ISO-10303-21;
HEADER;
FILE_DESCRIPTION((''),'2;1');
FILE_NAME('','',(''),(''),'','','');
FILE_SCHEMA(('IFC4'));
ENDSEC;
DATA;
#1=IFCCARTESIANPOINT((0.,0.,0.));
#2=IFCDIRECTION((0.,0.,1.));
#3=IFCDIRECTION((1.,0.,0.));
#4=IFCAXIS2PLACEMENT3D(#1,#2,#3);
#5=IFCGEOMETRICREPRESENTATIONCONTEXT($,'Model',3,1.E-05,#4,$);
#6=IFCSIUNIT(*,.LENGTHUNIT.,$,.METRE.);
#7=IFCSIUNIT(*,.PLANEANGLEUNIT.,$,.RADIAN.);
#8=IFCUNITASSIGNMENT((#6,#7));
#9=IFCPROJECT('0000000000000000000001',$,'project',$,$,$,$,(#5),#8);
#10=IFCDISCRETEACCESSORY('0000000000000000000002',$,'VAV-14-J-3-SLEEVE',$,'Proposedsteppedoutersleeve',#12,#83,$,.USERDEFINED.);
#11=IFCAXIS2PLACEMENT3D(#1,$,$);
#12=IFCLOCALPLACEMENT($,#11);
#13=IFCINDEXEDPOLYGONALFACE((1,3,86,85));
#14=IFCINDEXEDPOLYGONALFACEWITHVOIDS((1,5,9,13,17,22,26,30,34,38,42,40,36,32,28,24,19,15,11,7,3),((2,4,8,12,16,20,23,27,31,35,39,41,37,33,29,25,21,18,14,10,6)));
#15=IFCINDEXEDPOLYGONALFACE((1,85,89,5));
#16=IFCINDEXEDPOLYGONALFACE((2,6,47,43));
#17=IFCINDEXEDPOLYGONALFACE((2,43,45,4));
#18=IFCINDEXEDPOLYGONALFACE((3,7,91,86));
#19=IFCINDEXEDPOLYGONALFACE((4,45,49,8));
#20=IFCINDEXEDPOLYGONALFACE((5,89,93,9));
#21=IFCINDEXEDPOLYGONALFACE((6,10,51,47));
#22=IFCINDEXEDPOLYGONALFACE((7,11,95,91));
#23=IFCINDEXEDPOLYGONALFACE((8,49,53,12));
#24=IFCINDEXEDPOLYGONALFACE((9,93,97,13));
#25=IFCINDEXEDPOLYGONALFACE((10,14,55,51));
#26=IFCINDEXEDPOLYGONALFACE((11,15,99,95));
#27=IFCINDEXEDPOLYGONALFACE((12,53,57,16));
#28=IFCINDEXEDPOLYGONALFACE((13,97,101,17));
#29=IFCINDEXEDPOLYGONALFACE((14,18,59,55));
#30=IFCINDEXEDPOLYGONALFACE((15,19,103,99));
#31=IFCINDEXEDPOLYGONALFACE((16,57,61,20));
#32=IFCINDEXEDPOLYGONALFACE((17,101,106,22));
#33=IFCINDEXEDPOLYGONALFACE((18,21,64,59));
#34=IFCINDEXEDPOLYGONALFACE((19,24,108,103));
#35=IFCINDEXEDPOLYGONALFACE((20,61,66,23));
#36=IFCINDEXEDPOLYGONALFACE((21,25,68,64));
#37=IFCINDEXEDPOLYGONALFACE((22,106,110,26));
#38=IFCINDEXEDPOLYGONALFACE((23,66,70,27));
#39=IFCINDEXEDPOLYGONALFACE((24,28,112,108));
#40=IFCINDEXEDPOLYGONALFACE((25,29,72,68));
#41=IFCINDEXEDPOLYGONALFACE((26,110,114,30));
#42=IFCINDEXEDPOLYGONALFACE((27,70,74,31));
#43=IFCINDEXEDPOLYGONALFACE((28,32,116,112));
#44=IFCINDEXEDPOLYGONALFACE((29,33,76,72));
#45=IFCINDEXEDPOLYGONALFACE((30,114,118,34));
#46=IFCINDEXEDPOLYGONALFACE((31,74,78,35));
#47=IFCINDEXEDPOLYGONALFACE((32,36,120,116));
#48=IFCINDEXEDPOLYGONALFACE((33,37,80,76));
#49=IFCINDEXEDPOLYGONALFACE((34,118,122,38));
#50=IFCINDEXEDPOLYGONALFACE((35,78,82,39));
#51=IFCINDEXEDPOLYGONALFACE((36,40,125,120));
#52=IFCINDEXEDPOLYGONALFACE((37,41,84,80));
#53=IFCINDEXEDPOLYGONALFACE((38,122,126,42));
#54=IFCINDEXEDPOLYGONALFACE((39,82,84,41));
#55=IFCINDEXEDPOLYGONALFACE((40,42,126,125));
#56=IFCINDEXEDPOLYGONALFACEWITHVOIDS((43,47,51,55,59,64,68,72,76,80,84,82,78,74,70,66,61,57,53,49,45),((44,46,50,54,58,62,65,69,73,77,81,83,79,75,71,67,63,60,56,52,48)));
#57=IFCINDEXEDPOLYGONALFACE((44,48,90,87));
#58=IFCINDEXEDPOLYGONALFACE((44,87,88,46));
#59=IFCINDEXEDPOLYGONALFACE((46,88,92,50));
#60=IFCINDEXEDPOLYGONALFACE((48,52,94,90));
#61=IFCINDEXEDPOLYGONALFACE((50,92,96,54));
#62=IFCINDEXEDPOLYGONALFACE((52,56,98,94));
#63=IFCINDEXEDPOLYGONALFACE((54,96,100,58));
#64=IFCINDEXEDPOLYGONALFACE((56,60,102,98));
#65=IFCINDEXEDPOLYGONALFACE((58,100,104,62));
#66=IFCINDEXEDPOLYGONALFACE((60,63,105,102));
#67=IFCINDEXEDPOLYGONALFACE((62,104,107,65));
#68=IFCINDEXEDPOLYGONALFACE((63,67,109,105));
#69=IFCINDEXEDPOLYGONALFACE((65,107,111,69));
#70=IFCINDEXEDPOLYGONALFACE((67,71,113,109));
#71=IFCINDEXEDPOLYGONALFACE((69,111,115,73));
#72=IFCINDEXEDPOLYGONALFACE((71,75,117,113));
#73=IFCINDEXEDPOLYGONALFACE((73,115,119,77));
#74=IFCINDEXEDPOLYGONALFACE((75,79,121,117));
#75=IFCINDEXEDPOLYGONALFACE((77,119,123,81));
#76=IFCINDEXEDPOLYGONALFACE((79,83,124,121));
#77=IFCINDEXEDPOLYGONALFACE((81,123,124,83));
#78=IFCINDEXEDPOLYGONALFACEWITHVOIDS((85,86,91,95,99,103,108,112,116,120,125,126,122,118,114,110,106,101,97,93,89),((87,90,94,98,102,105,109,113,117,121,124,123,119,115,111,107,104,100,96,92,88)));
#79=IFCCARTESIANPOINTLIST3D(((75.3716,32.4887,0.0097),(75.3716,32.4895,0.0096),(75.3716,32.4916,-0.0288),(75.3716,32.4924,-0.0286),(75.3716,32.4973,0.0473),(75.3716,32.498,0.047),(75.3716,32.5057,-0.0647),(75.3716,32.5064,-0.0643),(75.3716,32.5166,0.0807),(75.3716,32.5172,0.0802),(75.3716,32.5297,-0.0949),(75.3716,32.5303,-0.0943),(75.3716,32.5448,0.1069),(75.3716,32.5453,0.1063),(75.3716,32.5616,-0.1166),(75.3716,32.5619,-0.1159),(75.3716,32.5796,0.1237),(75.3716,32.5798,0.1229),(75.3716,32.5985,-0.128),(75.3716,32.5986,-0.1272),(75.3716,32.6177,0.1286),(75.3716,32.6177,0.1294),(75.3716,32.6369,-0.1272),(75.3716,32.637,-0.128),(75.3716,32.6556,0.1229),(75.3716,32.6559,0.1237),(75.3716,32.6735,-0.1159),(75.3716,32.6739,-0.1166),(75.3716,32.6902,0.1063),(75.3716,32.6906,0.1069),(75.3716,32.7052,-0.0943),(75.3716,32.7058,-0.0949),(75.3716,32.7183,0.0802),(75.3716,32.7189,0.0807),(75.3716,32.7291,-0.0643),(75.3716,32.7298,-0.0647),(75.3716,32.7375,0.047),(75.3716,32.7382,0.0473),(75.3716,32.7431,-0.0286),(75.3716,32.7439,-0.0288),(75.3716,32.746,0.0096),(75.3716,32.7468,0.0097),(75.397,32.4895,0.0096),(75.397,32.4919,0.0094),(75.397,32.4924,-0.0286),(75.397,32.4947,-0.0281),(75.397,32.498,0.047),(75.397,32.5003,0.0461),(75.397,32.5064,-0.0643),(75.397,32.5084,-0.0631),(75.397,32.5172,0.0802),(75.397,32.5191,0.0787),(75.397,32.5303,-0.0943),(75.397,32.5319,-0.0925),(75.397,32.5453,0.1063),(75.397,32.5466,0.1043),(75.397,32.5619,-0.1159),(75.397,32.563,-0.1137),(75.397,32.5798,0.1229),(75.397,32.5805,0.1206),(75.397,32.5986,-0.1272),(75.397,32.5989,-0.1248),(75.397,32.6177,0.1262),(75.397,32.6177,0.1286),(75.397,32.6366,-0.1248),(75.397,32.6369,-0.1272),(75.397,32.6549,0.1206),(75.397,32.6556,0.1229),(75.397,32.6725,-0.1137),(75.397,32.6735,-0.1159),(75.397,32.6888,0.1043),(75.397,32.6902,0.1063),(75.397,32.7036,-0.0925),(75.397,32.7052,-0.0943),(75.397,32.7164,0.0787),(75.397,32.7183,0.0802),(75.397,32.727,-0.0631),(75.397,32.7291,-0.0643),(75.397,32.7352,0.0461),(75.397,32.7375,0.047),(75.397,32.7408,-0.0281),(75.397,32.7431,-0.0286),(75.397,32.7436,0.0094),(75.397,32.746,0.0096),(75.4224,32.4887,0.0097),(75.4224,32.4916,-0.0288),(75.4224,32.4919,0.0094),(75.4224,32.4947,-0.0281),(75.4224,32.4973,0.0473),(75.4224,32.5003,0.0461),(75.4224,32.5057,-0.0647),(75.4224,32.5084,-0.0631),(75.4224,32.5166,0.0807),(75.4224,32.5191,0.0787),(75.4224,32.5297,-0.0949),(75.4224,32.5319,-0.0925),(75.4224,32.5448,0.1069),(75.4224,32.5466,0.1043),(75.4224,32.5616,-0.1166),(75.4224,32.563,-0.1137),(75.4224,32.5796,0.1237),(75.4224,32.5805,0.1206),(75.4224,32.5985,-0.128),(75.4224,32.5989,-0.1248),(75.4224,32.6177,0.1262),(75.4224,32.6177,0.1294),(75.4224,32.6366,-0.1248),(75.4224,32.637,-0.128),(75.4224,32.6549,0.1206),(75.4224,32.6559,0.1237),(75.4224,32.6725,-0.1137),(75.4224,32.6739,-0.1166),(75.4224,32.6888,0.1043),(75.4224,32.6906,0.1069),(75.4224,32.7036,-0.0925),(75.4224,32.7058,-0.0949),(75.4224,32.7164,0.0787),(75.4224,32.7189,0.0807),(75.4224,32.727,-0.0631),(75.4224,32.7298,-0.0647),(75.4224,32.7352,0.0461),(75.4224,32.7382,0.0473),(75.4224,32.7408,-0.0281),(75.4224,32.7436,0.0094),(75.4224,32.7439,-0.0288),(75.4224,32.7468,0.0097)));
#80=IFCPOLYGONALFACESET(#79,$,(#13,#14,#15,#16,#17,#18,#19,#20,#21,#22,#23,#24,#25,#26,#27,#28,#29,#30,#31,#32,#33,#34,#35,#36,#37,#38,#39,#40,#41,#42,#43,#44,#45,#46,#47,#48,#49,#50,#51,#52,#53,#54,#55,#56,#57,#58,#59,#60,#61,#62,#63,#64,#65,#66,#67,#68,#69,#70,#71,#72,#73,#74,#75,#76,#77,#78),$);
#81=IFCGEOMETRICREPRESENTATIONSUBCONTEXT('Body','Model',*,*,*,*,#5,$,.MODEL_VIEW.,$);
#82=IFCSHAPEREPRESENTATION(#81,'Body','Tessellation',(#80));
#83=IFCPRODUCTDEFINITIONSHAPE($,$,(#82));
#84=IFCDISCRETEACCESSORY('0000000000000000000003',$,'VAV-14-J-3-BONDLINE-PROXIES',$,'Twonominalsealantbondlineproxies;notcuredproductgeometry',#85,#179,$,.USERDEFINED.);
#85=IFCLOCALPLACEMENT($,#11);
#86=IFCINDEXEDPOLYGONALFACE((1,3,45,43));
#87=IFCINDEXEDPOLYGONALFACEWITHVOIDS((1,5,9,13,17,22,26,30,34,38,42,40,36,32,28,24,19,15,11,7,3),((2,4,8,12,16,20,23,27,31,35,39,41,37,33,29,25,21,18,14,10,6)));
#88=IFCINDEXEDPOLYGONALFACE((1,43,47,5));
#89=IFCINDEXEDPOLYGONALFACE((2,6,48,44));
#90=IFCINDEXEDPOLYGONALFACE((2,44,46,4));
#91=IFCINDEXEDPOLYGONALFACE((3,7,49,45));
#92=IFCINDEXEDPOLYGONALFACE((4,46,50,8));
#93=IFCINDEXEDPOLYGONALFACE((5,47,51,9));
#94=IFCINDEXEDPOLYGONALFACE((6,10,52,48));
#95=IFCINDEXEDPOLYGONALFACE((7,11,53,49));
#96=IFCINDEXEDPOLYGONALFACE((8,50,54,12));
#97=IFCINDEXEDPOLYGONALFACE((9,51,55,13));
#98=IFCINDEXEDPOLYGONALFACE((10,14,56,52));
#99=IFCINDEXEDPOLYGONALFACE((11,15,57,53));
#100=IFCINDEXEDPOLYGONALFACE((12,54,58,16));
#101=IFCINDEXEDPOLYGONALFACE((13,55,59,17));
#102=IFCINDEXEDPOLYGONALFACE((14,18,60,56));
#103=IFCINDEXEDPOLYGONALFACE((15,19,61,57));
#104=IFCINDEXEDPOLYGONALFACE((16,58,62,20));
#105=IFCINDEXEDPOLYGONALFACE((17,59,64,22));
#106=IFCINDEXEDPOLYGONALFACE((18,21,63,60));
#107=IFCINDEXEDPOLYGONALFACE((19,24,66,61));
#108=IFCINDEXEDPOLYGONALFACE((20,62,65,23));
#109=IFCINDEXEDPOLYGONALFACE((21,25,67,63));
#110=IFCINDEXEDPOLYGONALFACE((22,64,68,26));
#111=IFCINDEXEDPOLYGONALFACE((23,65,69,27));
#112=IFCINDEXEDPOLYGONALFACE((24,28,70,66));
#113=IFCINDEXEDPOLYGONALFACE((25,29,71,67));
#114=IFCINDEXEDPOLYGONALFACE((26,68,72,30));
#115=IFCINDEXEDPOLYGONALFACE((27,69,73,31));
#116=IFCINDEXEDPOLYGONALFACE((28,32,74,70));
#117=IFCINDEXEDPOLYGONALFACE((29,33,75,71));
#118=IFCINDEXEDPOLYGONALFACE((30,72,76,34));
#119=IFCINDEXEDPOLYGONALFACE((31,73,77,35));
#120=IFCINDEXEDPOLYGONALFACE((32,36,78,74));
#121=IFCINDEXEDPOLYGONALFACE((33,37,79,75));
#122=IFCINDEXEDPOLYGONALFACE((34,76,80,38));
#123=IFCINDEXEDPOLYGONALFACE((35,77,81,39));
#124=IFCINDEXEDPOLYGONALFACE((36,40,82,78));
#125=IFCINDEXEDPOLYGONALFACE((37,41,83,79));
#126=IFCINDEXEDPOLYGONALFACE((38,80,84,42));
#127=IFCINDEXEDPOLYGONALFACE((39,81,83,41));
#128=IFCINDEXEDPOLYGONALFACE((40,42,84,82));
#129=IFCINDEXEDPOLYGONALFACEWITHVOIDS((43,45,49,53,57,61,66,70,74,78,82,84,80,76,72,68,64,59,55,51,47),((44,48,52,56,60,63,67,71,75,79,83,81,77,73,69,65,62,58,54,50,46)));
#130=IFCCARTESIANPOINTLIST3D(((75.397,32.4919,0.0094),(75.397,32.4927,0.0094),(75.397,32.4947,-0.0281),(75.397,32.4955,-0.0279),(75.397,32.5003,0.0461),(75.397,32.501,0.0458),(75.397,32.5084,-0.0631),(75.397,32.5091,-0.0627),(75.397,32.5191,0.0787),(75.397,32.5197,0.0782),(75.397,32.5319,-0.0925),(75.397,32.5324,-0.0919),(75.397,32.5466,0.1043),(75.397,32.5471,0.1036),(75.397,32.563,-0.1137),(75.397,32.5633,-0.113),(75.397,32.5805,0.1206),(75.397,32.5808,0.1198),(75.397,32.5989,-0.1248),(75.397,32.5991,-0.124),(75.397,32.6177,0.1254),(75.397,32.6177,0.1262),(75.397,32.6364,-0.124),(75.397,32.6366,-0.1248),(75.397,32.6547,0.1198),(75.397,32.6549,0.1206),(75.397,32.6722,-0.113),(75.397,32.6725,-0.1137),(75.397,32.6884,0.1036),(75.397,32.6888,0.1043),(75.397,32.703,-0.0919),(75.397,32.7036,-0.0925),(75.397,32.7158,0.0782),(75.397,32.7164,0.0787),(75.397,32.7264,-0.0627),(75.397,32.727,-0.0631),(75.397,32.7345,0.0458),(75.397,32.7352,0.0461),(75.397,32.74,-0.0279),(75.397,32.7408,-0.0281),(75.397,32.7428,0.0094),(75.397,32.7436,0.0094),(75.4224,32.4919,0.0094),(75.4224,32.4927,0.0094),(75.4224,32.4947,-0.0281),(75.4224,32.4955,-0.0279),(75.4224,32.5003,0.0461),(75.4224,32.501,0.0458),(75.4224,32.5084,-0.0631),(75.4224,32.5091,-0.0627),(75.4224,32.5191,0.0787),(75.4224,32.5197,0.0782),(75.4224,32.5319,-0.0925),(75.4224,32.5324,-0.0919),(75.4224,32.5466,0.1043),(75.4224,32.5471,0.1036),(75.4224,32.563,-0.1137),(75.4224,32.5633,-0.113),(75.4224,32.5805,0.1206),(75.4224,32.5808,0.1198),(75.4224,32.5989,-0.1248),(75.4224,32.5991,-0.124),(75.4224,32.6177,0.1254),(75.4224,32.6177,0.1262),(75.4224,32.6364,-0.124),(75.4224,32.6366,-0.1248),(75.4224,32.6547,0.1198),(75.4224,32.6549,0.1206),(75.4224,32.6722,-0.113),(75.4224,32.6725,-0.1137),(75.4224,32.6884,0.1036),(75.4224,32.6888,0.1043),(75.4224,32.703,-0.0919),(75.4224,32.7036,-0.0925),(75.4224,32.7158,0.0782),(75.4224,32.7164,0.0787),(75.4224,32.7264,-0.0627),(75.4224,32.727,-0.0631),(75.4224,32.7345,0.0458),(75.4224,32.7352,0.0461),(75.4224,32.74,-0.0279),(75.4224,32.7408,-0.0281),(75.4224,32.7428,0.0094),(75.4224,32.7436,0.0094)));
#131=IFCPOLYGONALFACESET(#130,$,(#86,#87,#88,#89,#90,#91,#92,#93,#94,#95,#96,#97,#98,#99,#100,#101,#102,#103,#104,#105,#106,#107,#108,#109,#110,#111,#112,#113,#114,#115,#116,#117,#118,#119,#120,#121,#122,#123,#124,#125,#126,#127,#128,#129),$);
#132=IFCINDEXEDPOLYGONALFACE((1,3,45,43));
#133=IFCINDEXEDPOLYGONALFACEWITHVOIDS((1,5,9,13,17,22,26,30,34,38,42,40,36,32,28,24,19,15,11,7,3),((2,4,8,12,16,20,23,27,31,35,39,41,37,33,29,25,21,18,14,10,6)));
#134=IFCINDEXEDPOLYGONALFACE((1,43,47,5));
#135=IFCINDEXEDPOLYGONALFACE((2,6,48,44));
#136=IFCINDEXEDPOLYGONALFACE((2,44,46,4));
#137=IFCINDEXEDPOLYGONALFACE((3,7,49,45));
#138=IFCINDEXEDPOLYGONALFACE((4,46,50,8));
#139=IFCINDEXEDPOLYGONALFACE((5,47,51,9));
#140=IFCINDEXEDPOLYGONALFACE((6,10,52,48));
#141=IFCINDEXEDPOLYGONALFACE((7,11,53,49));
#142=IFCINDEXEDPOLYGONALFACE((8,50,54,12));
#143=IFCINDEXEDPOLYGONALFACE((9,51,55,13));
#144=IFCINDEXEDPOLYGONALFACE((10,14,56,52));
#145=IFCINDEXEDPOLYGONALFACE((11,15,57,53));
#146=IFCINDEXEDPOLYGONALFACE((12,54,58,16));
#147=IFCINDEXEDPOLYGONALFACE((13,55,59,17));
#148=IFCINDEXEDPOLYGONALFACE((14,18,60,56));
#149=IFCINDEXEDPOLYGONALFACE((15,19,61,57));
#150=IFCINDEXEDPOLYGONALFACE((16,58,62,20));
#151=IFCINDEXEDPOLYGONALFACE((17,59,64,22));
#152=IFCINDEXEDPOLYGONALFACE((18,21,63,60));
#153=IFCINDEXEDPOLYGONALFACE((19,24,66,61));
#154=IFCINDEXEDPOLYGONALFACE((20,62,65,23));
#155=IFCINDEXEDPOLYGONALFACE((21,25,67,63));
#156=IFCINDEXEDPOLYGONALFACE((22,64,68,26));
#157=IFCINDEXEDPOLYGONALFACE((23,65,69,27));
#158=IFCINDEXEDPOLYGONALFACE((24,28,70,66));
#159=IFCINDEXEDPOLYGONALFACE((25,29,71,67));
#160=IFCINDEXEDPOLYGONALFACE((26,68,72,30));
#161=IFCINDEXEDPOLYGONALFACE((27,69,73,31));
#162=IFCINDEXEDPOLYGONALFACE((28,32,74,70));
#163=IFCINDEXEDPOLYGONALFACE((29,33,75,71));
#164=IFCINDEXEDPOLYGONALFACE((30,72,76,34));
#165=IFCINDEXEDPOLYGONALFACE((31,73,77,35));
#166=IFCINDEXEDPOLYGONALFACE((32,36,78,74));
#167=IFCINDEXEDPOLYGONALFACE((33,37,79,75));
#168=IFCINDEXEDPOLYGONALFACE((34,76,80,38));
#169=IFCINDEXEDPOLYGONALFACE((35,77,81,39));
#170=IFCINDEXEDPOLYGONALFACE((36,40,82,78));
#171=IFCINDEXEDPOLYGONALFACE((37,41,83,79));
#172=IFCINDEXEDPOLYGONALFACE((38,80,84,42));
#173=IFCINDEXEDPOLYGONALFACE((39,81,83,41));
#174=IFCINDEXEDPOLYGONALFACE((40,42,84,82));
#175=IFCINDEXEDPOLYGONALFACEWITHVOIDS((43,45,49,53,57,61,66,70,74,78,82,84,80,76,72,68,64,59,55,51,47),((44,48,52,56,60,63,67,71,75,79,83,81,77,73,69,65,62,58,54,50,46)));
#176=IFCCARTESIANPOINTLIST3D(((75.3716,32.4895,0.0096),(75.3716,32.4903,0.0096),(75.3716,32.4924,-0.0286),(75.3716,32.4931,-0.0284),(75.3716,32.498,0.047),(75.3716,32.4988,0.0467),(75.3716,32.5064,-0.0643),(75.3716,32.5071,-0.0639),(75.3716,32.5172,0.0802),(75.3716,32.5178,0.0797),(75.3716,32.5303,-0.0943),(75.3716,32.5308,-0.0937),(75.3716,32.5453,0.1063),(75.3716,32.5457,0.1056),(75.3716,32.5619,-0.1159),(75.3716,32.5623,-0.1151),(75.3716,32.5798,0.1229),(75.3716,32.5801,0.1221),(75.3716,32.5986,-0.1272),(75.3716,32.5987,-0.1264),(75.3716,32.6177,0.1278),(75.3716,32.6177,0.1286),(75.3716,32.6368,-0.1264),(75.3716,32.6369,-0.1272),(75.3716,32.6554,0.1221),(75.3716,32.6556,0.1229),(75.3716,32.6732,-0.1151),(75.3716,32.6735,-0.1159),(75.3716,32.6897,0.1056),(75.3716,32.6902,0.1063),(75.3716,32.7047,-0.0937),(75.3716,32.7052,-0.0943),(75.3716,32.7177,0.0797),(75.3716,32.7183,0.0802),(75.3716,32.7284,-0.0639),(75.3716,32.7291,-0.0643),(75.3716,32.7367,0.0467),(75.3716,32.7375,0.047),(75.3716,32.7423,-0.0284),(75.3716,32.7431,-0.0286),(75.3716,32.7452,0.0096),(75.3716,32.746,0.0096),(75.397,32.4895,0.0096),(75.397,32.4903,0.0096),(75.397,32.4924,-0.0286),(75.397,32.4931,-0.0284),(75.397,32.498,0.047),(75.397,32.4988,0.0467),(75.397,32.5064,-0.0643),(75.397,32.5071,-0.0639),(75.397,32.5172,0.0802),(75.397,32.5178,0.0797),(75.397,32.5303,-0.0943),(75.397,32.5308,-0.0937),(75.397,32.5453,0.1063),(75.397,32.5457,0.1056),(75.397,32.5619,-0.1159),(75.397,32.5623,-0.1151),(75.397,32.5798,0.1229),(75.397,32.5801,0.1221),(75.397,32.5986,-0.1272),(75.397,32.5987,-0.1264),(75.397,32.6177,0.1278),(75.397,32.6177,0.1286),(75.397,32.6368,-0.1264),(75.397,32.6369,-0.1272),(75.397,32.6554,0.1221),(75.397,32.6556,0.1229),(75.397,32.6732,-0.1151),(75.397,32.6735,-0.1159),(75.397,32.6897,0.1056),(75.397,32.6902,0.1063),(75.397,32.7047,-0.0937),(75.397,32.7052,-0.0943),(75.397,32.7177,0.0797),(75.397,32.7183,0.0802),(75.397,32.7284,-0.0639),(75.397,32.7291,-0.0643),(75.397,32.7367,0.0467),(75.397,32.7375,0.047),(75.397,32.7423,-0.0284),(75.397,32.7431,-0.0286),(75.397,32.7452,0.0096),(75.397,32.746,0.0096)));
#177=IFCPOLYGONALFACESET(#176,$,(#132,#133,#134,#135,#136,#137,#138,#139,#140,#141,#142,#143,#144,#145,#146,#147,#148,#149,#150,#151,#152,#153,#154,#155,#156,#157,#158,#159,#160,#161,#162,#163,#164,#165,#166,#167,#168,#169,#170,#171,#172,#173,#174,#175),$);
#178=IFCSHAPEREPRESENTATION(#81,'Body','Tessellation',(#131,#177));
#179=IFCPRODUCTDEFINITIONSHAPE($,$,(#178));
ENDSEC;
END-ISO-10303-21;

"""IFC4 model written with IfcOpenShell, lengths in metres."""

from ifc_helpers import new_model, entity, si_unit, frame, origin_with_axes, place, context, subcontext, project, element, save


model = new_model("IFC4")

# Units and contexts
model_context = context("Model", 3, precision=1e-05, world=origin_with_axes())
body_context = subcontext(model_context, "Body", "Model", "MODEL_VIEW")
ifc_project = project(units=[si_unit("LENGTHUNIT", "METRE"), si_unit("PLANEANGLEUNIT", "RADIAN")], contexts=[model_context])

# Discrete accessories
discrete_accessory_1_placement = place(None, frame((75.397, 32.6177, 0.0), z_axis=(0.0, -1.0, 0.0), x_axis=(0.0, 0.0, 1.0)))
element("IfcDiscreteAccessory", 1, at=discrete_accessory_1_placement, Name="VAV-14-J-3-SLEEVE", ObjectType="Proposedsteppedoutersleeve", PredefinedType="USERDEFINED", context=body_context, shape_type="SweptSolid", body=[
    entity("IfcRevolvedAreaSolid", entity("IfcArbitraryClosedProfileDef", "AREA", None, entity("IfcPolyline", [entity("IfcCartesianPoint", [0.1262, -0.0254]), entity("IfcCartesianPoint", [0.1294, -0.0254]), entity("IfcCartesianPoint", [0.1294, 0.0254]), entity("IfcCartesianPoint", [0.1286, 0.0254]), entity("IfcCartesianPoint", [0.1286, 0.0]), entity("IfcCartesianPoint", [0.1262, 0.0]), entity("IfcCartesianPoint", [0.1262, -0.0254])])), entity("IfcAxis2Placement3D", entity("IfcCartesianPoint", [0.0, 0.0, 0.0])), entity("IfcAxis1Placement", entity("IfcCartesianPoint", [0.0, 0.0, 0.0]), entity("IfcDirection", [0.0, 1.0, 0.0])), 6.283185),
])
discrete_accessory_2_placement = place(None, frame((75.397, 32.6177, 0.0), z_axis=(0.0, -1.0, 0.0), x_axis=(0.0, 0.0, 1.0)))
element("IfcDiscreteAccessory", 2, at=discrete_accessory_2_placement, Name="VAV-14-J-3-BONDLINE-PROXIES", ObjectType="Twonominalsealantbondlineproxies;notcuredproductgeometry", PredefinedType="USERDEFINED", context=body_context, shape_type="SweptSolid", body=[
    entity("IfcRevolvedAreaSolid", entity("IfcArbitraryClosedProfileDef", "AREA", None, entity("IfcPolyline", [entity("IfcCartesianPoint", [0.1254, -0.0254]), entity("IfcCartesianPoint", [0.1262, -0.0254]), entity("IfcCartesianPoint", [0.1262, 0.0]), entity("IfcCartesianPoint", [0.1254, 0.0]), entity("IfcCartesianPoint", [0.1254, -0.0254])])), entity("IfcAxis2Placement3D", entity("IfcCartesianPoint", [0.0, 0.0, 0.0])), entity("IfcAxis1Placement", entity("IfcCartesianPoint", [0.0, 0.0, 0.0]), entity("IfcDirection", [0.0, 1.0, 0.0])), 6.283185),
    entity("IfcRevolvedAreaSolid", entity("IfcArbitraryClosedProfileDef", "AREA", None, entity("IfcPolyline", [entity("IfcCartesianPoint", [0.1278, 0.0]), entity("IfcCartesianPoint", [0.1286, 0.0]), entity("IfcCartesianPoint", [0.1286, 0.0254]), entity("IfcCartesianPoint", [0.1278, 0.0254]), entity("IfcCartesianPoint", [0.1278, 0.0])])), entity("IfcAxis2Placement3D", entity("IfcCartesianPoint", [0.0, 0.0, 0.0])), entity("IfcAxis1Placement", entity("IfcCartesianPoint", [0.0, 0.0, 0.0]), entity("IfcDirection", [0.0, 1.0, 0.0])), 6.283185),
])

save(model, "model.ifc")
